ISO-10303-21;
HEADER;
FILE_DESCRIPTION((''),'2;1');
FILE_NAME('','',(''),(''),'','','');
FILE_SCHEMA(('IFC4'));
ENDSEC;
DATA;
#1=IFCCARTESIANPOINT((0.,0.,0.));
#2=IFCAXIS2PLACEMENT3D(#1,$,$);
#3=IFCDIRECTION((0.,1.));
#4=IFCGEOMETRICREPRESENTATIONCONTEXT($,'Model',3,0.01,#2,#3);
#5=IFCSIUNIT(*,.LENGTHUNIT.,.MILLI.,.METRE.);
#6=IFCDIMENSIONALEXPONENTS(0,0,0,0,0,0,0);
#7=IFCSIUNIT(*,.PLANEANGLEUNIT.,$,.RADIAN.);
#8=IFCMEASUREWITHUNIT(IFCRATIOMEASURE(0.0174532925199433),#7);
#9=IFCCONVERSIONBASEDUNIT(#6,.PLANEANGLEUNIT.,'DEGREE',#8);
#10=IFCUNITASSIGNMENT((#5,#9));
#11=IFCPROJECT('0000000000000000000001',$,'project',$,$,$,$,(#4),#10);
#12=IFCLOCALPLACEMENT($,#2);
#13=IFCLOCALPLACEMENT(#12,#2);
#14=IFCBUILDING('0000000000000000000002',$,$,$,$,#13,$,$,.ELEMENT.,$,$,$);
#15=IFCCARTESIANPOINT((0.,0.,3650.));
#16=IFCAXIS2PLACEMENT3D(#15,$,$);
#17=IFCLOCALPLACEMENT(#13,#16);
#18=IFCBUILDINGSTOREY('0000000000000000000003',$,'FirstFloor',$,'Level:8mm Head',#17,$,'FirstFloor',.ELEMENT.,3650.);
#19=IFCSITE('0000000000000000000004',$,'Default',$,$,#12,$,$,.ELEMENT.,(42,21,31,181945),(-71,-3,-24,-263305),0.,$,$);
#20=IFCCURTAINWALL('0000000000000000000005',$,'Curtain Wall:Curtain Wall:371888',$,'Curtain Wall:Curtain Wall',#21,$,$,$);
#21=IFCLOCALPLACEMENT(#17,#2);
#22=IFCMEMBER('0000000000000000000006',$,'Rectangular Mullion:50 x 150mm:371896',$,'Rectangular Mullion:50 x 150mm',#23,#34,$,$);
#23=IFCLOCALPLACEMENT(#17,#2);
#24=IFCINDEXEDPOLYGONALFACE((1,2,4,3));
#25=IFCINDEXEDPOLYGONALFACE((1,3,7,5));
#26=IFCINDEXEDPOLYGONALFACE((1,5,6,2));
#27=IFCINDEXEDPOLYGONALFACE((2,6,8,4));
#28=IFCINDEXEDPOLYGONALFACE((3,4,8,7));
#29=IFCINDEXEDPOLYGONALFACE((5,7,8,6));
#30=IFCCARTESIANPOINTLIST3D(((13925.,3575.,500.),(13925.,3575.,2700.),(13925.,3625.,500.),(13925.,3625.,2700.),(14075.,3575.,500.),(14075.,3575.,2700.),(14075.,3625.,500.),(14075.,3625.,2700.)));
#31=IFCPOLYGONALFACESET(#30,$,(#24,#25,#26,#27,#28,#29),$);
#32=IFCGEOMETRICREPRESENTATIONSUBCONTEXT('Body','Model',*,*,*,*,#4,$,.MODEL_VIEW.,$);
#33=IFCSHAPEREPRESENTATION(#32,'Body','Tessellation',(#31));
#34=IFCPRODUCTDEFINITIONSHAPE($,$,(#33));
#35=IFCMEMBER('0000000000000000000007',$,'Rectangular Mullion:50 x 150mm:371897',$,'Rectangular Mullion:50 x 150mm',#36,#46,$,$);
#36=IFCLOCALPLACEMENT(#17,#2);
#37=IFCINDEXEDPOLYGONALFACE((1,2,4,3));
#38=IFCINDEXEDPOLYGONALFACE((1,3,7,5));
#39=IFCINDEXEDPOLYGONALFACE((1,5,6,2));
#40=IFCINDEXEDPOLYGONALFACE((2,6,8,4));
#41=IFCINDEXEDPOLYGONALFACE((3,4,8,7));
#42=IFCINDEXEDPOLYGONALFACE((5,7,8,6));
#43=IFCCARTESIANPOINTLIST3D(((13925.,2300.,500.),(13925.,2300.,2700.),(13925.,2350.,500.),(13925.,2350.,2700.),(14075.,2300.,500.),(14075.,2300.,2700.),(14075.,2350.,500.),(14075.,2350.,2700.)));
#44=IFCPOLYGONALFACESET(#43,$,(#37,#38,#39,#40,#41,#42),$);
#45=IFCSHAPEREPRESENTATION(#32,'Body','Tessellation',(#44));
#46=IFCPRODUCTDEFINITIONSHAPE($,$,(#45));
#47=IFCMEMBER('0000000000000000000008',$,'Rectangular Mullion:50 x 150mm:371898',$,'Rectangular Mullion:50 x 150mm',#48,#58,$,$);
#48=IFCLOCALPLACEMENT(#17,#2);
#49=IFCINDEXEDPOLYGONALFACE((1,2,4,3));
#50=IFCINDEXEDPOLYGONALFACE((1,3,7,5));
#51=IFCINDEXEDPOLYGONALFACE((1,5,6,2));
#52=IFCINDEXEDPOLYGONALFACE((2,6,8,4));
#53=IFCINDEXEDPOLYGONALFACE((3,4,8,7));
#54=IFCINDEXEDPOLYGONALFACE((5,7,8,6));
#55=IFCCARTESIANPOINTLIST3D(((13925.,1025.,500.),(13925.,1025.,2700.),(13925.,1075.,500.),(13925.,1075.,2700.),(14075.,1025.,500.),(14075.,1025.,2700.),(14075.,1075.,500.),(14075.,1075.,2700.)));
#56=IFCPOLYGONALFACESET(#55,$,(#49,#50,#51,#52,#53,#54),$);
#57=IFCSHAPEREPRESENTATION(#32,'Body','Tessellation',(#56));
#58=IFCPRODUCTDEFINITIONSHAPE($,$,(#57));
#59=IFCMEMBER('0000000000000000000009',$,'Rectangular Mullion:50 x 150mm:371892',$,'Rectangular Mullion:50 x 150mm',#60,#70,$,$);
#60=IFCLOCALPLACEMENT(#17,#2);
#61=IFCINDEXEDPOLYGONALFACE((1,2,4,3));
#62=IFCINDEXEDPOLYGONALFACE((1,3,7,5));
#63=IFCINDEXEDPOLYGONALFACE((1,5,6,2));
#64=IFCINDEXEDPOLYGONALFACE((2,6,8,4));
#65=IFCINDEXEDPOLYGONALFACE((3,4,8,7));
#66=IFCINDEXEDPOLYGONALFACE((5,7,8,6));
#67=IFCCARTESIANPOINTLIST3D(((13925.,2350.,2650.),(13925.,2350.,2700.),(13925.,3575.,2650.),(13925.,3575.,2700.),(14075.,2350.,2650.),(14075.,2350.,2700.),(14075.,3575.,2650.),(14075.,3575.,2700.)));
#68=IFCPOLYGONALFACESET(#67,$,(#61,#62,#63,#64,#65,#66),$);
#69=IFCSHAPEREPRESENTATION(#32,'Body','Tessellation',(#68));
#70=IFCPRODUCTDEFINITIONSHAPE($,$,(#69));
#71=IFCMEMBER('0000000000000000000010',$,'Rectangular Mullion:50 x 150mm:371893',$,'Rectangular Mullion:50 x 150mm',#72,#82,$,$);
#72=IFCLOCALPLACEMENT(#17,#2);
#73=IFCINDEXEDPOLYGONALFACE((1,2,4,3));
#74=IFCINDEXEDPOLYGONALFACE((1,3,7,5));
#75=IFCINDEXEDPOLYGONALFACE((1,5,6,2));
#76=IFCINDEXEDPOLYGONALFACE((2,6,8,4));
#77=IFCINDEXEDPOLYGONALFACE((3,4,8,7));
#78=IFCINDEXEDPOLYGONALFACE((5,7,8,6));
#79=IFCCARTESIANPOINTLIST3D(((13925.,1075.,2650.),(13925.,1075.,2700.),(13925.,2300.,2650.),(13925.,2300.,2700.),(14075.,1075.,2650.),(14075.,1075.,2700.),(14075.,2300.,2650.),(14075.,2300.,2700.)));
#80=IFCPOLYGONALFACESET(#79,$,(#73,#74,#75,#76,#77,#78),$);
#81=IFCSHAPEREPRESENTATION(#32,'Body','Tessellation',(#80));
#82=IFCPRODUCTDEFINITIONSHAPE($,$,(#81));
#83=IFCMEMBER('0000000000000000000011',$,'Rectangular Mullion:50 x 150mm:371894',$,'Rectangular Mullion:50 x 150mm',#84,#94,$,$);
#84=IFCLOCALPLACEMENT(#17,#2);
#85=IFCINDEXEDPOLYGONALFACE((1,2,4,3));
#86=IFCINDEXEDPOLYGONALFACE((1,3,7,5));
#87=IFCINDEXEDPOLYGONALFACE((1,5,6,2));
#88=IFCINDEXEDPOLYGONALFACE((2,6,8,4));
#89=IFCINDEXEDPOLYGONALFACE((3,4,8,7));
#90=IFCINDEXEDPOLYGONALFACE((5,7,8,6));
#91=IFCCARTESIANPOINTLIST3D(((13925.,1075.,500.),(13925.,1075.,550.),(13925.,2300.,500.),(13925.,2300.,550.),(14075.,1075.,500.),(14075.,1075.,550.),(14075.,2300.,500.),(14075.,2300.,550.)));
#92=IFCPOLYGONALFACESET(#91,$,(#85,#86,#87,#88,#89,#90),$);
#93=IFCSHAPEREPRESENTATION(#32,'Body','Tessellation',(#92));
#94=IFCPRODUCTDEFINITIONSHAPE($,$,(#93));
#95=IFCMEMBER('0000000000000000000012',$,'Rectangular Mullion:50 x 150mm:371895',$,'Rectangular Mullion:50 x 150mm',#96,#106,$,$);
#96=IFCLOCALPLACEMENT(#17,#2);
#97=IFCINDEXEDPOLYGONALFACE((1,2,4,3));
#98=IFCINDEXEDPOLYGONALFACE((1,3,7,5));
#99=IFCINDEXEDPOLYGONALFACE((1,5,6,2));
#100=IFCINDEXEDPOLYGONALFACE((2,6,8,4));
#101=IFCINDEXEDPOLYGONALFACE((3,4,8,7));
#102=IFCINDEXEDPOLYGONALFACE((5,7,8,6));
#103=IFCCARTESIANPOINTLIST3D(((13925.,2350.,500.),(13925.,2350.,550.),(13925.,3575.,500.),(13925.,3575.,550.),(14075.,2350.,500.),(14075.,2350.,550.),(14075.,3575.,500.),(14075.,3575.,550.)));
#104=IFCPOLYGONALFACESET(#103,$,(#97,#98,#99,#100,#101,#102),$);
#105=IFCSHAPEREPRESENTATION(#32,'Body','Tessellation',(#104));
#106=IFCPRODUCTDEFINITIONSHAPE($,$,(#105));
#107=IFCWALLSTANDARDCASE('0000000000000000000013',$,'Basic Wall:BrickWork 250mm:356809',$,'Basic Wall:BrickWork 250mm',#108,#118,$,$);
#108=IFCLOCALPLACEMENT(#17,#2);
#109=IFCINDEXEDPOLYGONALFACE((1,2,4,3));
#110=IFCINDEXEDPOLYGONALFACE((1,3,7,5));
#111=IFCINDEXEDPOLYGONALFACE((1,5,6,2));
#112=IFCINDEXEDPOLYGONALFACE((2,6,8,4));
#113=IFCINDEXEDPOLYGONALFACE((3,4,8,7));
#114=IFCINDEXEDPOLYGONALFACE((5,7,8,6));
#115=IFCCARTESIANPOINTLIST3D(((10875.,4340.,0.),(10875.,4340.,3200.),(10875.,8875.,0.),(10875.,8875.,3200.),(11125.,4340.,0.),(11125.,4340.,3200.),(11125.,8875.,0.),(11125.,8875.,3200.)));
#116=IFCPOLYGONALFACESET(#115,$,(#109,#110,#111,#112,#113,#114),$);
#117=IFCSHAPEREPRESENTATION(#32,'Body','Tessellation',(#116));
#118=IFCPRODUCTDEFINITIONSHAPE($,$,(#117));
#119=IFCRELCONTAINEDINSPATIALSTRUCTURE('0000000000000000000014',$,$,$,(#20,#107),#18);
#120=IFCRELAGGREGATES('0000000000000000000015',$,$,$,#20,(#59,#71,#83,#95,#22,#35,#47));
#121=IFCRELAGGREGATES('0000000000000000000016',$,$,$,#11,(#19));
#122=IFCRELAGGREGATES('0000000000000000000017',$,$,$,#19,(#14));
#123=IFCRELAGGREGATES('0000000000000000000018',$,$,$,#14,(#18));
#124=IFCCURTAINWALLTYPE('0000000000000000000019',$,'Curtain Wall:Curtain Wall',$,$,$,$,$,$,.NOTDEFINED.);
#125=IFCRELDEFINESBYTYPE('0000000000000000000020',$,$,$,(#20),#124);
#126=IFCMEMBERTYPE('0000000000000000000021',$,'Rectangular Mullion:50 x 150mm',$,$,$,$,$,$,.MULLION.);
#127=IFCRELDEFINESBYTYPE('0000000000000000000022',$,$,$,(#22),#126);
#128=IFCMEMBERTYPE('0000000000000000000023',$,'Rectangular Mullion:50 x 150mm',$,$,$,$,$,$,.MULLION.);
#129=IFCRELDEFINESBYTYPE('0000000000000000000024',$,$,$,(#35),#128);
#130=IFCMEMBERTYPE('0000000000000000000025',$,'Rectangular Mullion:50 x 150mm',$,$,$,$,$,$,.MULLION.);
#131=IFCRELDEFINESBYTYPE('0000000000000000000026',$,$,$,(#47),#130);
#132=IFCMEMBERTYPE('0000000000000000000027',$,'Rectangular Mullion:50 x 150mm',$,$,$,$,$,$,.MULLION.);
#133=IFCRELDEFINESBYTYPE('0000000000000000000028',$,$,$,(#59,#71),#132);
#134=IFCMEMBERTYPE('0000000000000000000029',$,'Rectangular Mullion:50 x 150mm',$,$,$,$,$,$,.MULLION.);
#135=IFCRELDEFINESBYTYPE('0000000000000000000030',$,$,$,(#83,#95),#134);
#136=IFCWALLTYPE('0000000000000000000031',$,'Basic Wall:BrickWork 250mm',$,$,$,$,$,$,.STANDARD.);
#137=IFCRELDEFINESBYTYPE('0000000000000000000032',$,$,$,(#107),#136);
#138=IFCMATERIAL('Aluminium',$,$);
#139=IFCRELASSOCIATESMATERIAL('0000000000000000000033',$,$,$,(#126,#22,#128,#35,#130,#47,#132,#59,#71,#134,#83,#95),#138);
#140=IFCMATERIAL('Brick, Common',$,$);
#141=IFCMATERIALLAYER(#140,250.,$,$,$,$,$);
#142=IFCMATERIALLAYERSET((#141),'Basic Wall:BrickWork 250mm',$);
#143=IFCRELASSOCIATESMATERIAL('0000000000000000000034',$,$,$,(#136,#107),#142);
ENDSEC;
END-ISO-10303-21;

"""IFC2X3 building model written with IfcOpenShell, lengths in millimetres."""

from ifc_helpers import new_model, entity, si_unit, converted_unit, direction, frame, frame_2d, origin, origin_2d_with_axis, place, context, subcontext, project, spatial, rectangle, extrude, source, transform, mapped, material, layer, layer_set, layer_usage, type_object, type_shapes, element, aggregate, save


model = new_model("IFC2X3")

# Units and contexts
model_context = context("Model", 3, precision=0.01, world=origin(), true_north=direction((0.0, 1.0)))
body_context = subcontext(model_context, "Body", "Model", "MODEL_VIEW")
ifc_project = project(units=[si_unit("LENGTHUNIT", "METRE", prefix="MILLI"), converted_unit("PLANEANGLEUNIT", "DEGREE", entity("IfcRatioMeasure", 0.0174532925199433), si_unit("PLANEANGLEUNIT", "RADIAN"), dimensions=[0, 0, 0, 0, 0, 0, 0])], contexts=[model_context])

# Site, building, storey
site_placement = place(None, origin())
site = spatial("IfcSite", under=ifc_project, at=site_placement, Name="Default", CompositionType="ELEMENT", RefLatitude=(42, 21, 31, 181945), RefLongitude=(-71, -3, -24, -263305), RefElevation=0.0)
building_placement = place(site_placement, origin())
building = spatial("IfcBuilding", under=site, at=building_placement, CompositionType="ELEMENT")
storey_placement = place(building_placement, frame((0.0, 0.0, 3650.0)))
storey = spatial("IfcBuildingStorey", under=building, at=storey_placement, Name="FirstFloor", ObjectType="Level:8mm Head", LongName="FirstFloor", CompositionType="ELEMENT", Elevation=3650.0)

# Curtain wall, members
curtain_wall_type = type_object("IfcCurtainWallType", Name="Curtain Wall:Curtain Wall", PredefinedType="NOTDEFINED")
curtain_wall_placement = place(storey_placement, frame((0.0, 0.0, -3650.0)))
curtain_wall = element("IfcCurtainWall", 1, at=curtain_wall_placement, inside=storey, type_object=curtain_wall_type, Name="Curtain Wall:Curtain Wall:371888", ObjectType="Curtain Wall:Curtain Wall")
ifc_material_1 = material(Name="Aluminium")
member_type_1 = type_object("IfcMemberType", Name="Rectangular Mullion:50 x 150mm", PredefinedType="MULLION", material=ifc_material_1)
shared_shape_1 = source(origin(), body_context, "Body", "SweptSolid", [
    extrude(rectangle(XDim=150.0, YDim=50.0, at=origin_2d_with_axis()), frame((-25.0, 0.0, -2200.0), z_axis=(0.0, 0.0, 1.0), x_axis=(0.0, -1.0, 0.0)), (0.0, 0.0, 1.0), 2200.0),
])
type_shapes(member_type_1, [shared_shape_1])
member_1_placement = place(storey_placement, frame((14000.0, 3625.0, 500.0), z_axis=(0.0, 0.0, -1.0), x_axis=(0.0, 1.0, 0.0)))
member_1 = element("IfcMember", 2, at=member_1_placement, type_object=member_type_1, material=ifc_material_1, Name="Rectangular Mullion:50 x 150mm:371896", ObjectType="Rectangular Mullion:50 x 150mm", context=body_context, shape_type="MappedRepresentation", body=[
    mapped(shared_shape_1, transform((0.0, 0.0, 0.0), scale=1.0)),
])
member_type_2 = type_object("IfcMemberType", Name="Rectangular Mullion:50 x 150mm", PredefinedType="MULLION", material=ifc_material_1)
shared_shape_2 = source(origin(), body_context, "Body", "SweptSolid", [
    extrude(rectangle(XDim=150.0, YDim=50.0, at=origin_2d_with_axis()), frame((0.0, 0.0, -2200.0), z_axis=(0.0, 0.0, 1.0), x_axis=(0.0, -1.0, 0.0)), (0.0, 0.0, 1.0), 2200.0),
])
type_shapes(member_type_2, [shared_shape_2])
member_2_placement = place(storey_placement, frame((14000.0, 2325.0, 500.0), z_axis=(0.0, 0.0, -1.0), x_axis=(0.0, 1.0, 0.0)))
member_2 = element("IfcMember", 3, at=member_2_placement, type_object=member_type_2, material=ifc_material_1, Name="Rectangular Mullion:50 x 150mm:371897", ObjectType="Rectangular Mullion:50 x 150mm", context=body_context, shape_type="MappedRepresentation", body=[
    mapped(shared_shape_2, transform((0.0, 0.0, 0.0), scale=1.0)),
])
member_type_3 = type_object("IfcMemberType", Name="Rectangular Mullion:50 x 150mm", PredefinedType="MULLION", material=ifc_material_1)
shared_shape_3 = source(origin(), body_context, "Body", "SweptSolid", [
    extrude(rectangle(XDim=150.0, YDim=50.0, at=origin_2d_with_axis()), frame((-25.0, 0.0, -2200.0), z_axis=(0.0, 0.0, 1.0), x_axis=(0.0, -1.0, 0.0)), (0.0, 0.0, 1.0), 2200.0),
])
type_shapes(member_type_3, [shared_shape_3])
member_3_placement = place(storey_placement, frame((14000.0, 1025.0, 2700.0), z_axis=(0.0, 0.0, 1.0), x_axis=(0.0, -1.0, 0.0)))
member_3 = element("IfcMember", 4, at=member_3_placement, type_object=member_type_3, material=ifc_material_1, Name="Rectangular Mullion:50 x 150mm:371898", ObjectType="Rectangular Mullion:50 x 150mm", context=body_context, shape_type="MappedRepresentation", body=[
    mapped(shared_shape_3, transform((0.0, 0.0, 0.0), scale=1.0)),
])
member_type_4 = type_object("IfcMemberType", Name="Rectangular Mullion:50 x 150mm", PredefinedType="MULLION", material=ifc_material_1)
shared_shape_4 = source(origin(), body_context, "Body", "SweptSolid", [
    extrude(rectangle(XDim=150.0, YDim=50.0, at=origin_2d_with_axis()), frame((-25.0, 0.0, -1225.0), z_axis=(0.0, 0.0, 1.0), x_axis=(0.0, -1.0, 0.0)), (0.0, 0.0, 1.0), 1225.0),
])
type_shapes(member_type_4, [shared_shape_4])
member_4_placement = place(storey_placement, frame((14000.0, 3575.0, 2700.0), z_axis=(0.0, 1.0, 0.0), x_axis=(0.0, 0.0, 1.0)))
member_4 = element("IfcMember", 5, at=member_4_placement, type_object=member_type_4, material=ifc_material_1, Name="Rectangular Mullion:50 x 150mm:371892", ObjectType="Rectangular Mullion:50 x 150mm", context=body_context, shape_type="MappedRepresentation", body=[
    mapped(shared_shape_4, transform((0.0, 0.0, 0.0), scale=1.0)),
])
member_5_placement = place(storey_placement, frame((14000.0, 2300.0, 2700.0), z_axis=(0.0, 1.0, 0.0), x_axis=(0.0, 0.0, 1.0)))
member_5 = element("IfcMember", 6, at=member_5_placement, type_object=member_type_4, material=ifc_material_1, Name="Rectangular Mullion:50 x 150mm:371893", ObjectType="Rectangular Mullion:50 x 150mm", context=body_context, shape_type="MappedRepresentation", body=[
    mapped(shared_shape_4, transform((0.0, 0.0, 0.0), scale=1.0)),
])
member_type_5 = type_object("IfcMemberType", Name="Rectangular Mullion:50 x 150mm", PredefinedType="MULLION", material=ifc_material_1)
shared_shape_5 = source(origin(), body_context, "Body", "SweptSolid", [
    extrude(rectangle(XDim=150.0, YDim=50.0, at=origin_2d_with_axis()), frame((-25.0, 0.0, -1225.0), z_axis=(0.0, 0.0, 1.0), x_axis=(0.0, -1.0, 0.0)), (0.0, 0.0, 1.0), 1225.0),
])
type_shapes(member_type_5, [shared_shape_5])
member_6_placement = place(storey_placement, frame((14000.0, 1075.0, 500.0), z_axis=(0.0, -1.0, 0.0), x_axis=(0.0, 0.0, -1.0)))
member_6 = element("IfcMember", 7, at=member_6_placement, type_object=member_type_5, material=ifc_material_1, Name="Rectangular Mullion:50 x 150mm:371894", ObjectType="Rectangular Mullion:50 x 150mm", context=body_context, shape_type="MappedRepresentation", body=[
    mapped(shared_shape_5, transform((0.0, 0.0, 0.0), scale=1.0)),
])
member_7_placement = place(storey_placement, frame((14000.0, 2350.0, 500.0), z_axis=(0.0, -1.0, 0.0), x_axis=(0.0, 0.0, -1.0)))
member_7 = element("IfcMember", 8, at=member_7_placement, type_object=member_type_5, material=ifc_material_1, Name="Rectangular Mullion:50 x 150mm:371895", ObjectType="Rectangular Mullion:50 x 150mm", context=body_context, shape_type="MappedRepresentation", body=[
    mapped(shared_shape_5, transform((0.0, 0.0, 0.0), scale=1.0)),
])
aggregate(curtain_wall, [member_4, member_5, member_6, member_7, member_1, member_2, member_3])

# Wall
ifc_material_2 = material(Name="Brick, Common")
ifc_layer_1 = layer(ifc_material_2, 250.0)
ifc_layer_set_1 = layer_set([ifc_layer_1], Name="Basic Wall:BrickWork 250mm")
ifc_layer_usage_1 = layer_usage(ifc_layer_set_1, "AXIS2", "POSITIVE", -125.0)
wall_type_1 = type_object("IfcWallType", Name="Basic Wall:BrickWork 250mm", PredefinedType="STANDARD", material=ifc_layer_set_1)
wall_1_placement = place(storey_placement, frame((11000.0, 8875.0, 0.0), z_axis=(0.0, 0.0, 1.0), x_axis=(0.0, -1.0, 0.0)))
element("IfcWallStandardCase", 9, at=wall_1_placement, inside=storey, type_object=wall_type_1, material=ifc_layer_usage_1, Name="Basic Wall:BrickWork 250mm:356809", ObjectType="Basic Wall:BrickWork 250mm", context=body_context, shape_type="SweptSolid", body=[
    extrude(rectangle(XDim=4535.0, YDim=250.0, at=frame_2d((2267.5, 0.0), x_axis=(-1.0, 0.0))), origin(), (0.0, 0.0, 1.0), 3200.0),
])

save(model, "model.ifc")
